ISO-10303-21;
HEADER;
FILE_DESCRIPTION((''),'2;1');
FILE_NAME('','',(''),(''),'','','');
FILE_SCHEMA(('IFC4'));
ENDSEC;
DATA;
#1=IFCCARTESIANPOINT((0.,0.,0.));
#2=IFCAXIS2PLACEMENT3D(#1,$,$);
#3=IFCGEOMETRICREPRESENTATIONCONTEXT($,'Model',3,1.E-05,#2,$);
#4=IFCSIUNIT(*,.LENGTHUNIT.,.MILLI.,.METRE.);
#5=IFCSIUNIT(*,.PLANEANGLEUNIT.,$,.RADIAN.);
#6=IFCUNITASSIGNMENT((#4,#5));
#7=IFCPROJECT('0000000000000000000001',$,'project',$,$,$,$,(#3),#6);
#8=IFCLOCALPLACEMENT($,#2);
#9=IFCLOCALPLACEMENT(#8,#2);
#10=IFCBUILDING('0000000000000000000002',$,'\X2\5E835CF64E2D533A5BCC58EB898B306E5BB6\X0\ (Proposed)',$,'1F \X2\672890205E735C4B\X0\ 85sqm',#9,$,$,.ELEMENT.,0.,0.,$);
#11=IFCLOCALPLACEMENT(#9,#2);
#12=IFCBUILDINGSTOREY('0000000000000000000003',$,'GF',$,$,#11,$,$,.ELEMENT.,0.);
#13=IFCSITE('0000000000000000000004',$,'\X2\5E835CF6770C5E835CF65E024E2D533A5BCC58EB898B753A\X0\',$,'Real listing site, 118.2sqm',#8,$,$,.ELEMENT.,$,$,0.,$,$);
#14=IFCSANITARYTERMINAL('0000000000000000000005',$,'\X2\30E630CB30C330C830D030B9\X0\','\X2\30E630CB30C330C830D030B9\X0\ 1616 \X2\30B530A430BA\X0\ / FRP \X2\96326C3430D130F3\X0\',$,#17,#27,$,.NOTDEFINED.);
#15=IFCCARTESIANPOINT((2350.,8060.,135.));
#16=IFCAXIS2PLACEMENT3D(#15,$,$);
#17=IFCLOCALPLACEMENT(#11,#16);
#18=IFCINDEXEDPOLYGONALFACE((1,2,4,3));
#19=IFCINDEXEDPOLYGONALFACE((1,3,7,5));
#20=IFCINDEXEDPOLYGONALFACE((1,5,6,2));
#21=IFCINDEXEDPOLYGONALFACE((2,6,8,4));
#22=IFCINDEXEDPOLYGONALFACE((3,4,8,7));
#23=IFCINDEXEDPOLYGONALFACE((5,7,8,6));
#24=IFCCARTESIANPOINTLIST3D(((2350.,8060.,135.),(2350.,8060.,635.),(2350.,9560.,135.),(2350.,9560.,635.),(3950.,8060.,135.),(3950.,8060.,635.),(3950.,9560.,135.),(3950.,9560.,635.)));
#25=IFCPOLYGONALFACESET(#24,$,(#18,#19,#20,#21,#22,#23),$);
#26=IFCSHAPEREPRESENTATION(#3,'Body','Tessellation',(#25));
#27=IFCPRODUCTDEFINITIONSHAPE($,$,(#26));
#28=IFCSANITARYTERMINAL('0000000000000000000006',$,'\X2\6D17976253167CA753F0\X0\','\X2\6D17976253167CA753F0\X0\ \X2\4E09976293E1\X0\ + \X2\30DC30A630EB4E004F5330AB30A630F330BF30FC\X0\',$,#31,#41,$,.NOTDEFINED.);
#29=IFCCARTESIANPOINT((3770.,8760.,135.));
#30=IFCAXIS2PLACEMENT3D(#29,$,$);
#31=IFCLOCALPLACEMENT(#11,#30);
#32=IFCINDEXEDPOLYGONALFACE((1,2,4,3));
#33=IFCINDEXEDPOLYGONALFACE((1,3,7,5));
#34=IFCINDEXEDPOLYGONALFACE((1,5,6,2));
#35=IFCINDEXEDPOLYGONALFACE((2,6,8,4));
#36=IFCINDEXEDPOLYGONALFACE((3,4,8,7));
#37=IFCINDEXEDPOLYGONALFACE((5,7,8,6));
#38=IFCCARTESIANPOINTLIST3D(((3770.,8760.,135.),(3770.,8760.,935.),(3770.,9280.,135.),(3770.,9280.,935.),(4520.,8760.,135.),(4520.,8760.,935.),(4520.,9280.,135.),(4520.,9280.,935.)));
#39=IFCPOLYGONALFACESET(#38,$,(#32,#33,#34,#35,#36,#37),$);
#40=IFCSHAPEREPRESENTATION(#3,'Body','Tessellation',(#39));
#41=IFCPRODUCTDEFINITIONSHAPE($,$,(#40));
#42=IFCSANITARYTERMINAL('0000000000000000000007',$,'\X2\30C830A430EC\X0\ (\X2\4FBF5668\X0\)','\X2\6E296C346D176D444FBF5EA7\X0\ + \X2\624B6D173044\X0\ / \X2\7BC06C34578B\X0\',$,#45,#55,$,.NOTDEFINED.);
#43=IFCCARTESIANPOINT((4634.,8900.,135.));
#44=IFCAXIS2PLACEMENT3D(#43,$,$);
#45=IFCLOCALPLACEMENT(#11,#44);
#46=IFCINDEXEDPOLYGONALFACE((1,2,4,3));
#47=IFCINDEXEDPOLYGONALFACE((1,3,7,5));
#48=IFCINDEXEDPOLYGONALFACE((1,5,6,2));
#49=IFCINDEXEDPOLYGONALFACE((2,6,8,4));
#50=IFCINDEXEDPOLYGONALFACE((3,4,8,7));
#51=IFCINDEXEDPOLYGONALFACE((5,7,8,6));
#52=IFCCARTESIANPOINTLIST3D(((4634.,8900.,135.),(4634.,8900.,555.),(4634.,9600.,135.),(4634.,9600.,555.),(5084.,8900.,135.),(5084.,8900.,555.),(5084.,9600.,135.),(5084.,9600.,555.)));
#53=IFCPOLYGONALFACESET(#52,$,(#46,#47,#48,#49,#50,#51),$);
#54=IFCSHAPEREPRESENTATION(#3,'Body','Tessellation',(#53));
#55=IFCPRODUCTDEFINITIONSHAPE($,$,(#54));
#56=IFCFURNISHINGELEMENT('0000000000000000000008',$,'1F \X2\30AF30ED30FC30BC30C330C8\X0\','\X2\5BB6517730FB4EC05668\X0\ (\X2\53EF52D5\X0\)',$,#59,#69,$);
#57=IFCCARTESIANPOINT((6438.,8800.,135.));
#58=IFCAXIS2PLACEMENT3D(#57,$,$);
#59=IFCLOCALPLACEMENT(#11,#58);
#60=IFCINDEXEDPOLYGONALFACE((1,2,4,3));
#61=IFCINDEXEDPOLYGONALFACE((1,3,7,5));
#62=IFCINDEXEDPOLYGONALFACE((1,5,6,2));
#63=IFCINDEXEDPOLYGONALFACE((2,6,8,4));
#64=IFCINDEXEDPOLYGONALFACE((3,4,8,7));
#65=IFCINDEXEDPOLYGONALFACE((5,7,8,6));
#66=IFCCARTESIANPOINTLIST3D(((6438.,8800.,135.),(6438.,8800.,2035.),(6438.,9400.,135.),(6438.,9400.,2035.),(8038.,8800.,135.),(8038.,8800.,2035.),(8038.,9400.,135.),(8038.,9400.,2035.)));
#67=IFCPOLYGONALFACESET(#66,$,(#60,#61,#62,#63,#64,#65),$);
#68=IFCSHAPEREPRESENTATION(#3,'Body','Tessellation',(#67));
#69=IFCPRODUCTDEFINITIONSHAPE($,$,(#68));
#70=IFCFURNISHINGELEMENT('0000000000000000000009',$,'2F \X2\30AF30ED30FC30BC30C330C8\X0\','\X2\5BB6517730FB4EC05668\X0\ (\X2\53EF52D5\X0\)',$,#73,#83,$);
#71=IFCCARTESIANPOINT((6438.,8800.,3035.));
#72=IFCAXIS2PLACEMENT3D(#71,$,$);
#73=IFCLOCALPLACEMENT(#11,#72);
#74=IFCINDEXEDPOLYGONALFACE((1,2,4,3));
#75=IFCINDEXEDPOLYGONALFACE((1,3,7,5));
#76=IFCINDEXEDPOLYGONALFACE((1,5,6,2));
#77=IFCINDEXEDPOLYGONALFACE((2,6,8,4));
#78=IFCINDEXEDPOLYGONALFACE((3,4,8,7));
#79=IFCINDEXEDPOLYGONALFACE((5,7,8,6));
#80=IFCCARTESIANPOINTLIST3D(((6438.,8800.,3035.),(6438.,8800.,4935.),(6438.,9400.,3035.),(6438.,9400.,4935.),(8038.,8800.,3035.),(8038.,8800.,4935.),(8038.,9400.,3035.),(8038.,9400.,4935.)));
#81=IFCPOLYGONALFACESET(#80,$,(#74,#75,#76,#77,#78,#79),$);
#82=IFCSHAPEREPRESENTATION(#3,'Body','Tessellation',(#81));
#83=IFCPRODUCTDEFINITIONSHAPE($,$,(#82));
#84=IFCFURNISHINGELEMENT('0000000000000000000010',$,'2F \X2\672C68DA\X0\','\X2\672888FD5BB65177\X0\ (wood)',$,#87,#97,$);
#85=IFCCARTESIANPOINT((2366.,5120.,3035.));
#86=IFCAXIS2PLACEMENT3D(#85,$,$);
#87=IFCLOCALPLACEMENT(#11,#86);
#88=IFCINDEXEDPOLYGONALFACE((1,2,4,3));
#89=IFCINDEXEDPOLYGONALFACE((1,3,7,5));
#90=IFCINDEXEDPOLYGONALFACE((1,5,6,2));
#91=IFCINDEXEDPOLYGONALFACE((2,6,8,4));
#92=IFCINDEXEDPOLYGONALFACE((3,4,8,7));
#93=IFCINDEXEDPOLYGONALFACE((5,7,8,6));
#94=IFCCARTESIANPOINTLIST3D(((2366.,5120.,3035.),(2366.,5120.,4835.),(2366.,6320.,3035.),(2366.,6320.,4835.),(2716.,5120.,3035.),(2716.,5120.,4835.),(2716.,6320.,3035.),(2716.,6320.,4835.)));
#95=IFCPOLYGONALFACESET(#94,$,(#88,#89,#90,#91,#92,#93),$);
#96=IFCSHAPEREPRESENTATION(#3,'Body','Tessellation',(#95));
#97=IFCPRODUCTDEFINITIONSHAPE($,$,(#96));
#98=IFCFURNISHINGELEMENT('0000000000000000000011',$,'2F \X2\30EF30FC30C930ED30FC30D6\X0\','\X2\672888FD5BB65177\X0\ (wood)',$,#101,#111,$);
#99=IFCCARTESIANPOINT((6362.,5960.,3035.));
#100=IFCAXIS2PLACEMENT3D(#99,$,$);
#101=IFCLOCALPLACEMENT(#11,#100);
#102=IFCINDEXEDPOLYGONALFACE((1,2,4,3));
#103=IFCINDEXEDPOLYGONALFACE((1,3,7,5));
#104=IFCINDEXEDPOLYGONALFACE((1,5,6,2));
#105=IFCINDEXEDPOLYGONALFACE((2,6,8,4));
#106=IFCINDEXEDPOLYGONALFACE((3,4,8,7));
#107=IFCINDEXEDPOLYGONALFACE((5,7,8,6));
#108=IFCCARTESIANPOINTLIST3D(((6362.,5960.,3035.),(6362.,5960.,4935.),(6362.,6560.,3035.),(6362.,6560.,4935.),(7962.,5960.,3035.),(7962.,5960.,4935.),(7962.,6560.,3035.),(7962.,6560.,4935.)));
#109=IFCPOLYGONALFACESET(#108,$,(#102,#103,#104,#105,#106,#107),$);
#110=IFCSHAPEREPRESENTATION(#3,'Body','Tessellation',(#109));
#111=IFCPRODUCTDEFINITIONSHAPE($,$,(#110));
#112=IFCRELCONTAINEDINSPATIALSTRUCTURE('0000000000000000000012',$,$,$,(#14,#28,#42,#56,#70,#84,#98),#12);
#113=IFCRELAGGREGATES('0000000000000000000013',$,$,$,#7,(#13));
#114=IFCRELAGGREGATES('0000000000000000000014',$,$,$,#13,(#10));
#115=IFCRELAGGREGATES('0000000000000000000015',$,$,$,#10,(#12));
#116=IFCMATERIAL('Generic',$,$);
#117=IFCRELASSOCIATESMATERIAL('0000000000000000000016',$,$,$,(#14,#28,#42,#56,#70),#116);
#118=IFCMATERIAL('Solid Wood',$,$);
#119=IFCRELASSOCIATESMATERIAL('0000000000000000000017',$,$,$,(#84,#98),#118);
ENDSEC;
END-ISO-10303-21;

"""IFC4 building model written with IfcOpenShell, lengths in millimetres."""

from ifc_helpers import new_model, si_unit, frame, frame_2d, origin, place, context, project, spatial, rectangle, extrude, material, element, save


model = new_model("IFC4")

# Units and contexts
model_context = context("Model", 3, precision=1e-05, world=origin())
ifc_project = project(units=[si_unit("LENGTHUNIT", "METRE", prefix="MILLI"), si_unit("PLANEANGLEUNIT", "RADIAN")], contexts=[model_context])

# Site, building, storey
site_placement = place(None, origin())
site = spatial("IfcSite", under=ifc_project, at=site_placement, Name="広島県広島市中区富士見町", ObjectType="Real listing site, 118.2sqm", CompositionType="ELEMENT", RefElevation=0.0)
building_placement = place(site_placement, origin())
building = spatial("IfcBuilding", under=site, at=building_placement, Name="広島中区富士見の家 (Proposed)", ObjectType="1F 木造平屋 85sqm", CompositionType="ELEMENT", ElevationOfRefHeight=0.0, ElevationOfTerrain=0.0)
storey_placement = place(building_placement, origin())
storey = spatial("IfcBuildingStorey", under=building, at=storey_placement, Name="GF", CompositionType="ELEMENT", Elevation=0.0)

# Shared definitions
ifc_material_1 = material(Name="Solid Wood")

# Shared definitions
ifc_material_2 = material(Name="Generic")

# Sanitary terminals
sanitary_terminal_1_placement = place(storey_placement, frame((2350.0, 8060.0, 135.0)))
element("IfcSanitaryTerminal", 1, at=sanitary_terminal_1_placement, inside=storey, material=ifc_material_2, Name="ユニットバス", Description="ユニットバス 1616 サイズ / FRP 防水パン", PredefinedType="NOTDEFINED", context=model_context, shape_type="SweptSolid", body=[
    extrude(rectangle(XDim=1600.0, YDim=1500.0, at=frame_2d((800.0, 750.0))), frame((2350.0, 8060.0, 135.0)), (0.0, 0.0, 1.0), 500.0),
])
sanitary_terminal_2_placement = place(storey_placement, frame((3770.0, 8760.0, 135.0)))
element("IfcSanitaryTerminal", 2, at=sanitary_terminal_2_placement, inside=storey, material=ifc_material_2, Name="洗面化粧台", Description="洗面化粧台 三面鏡 + ボウル一体カウンター", PredefinedType="NOTDEFINED", context=model_context, shape_type="SweptSolid", body=[
    extrude(rectangle(XDim=750.0, YDim=520.0, at=frame_2d((375.0, 260.0))), frame((3770.0, 8760.0, 135.0)), (0.0, 0.0, 1.0), 800.0),
])
sanitary_terminal_3_placement = place(storey_placement, frame((4634.0, 8900.0, 135.0)))
element("IfcSanitaryTerminal", 3, at=sanitary_terminal_3_placement, inside=storey, material=ifc_material_2, Name="トイレ (便器)", Description="温水洗浄便座 + 手洗い / 節水型", PredefinedType="NOTDEFINED", context=model_context, shape_type="SweptSolid", body=[
    extrude(rectangle(XDim=450.0, YDim=700.0, at=frame_2d((225.0, 350.0))), frame((4634.0, 8900.0, 135.0)), (0.0, 0.0, 1.0), 420.0),
])

# Furnishing elements
furnishing_1_placement = place(storey_placement, frame((6438.0, 8800.0, 135.0)))
element("IfcFurnishingElement", 4, at=furnishing_1_placement, inside=storey, material=ifc_material_2, Name="1F クローゼット", Description="家具・什器 (可動)", context=model_context, shape_type="SweptSolid", body=[
    extrude(rectangle(XDim=1600.0, YDim=600.0, at=frame_2d((800.0, 300.0))), frame((6438.0, 8800.0, 135.0)), (0.0, 0.0, 1.0), 1900.0),
])
furnishing_2_placement = place(storey_placement, frame((6438.0, 8800.0, 3035.0)))
element("IfcFurnishingElement", 5, at=furnishing_2_placement, inside=storey, material=ifc_material_2, Name="2F クローゼット", Description="家具・什器 (可動)", context=model_context, shape_type="SweptSolid", body=[
    extrude(rectangle(XDim=1600.0, YDim=600.0, at=frame_2d((800.0, 300.0))), frame((6438.0, 8800.0, 3035.0)), (0.0, 0.0, 1.0), 1900.0),
])
furnishing_3_placement = place(storey_placement, frame((2366.0, 5120.0, 3035.0)))
element("IfcFurnishingElement", 6, at=furnishing_3_placement, inside=storey, material=ifc_material_1, Name="2F 本棚", Description="木製家具 (wood)", context=model_context, shape_type="SweptSolid", body=[
    extrude(rectangle(XDim=350.0, YDim=1200.0, at=frame_2d((175.0, 600.0))), frame((2366.0, 5120.0, 3035.0)), (0.0, 0.0, 1.0), 1800.0),
])
furnishing_4_placement = place(storey_placement, frame((6362.0, 5960.0, 3035.0)))
element("IfcFurnishingElement", 7, at=furnishing_4_placement, inside=storey, material=ifc_material_1, Name="2F ワードローブ", Description="木製家具 (wood)", context=model_context, shape_type="SweptSolid", body=[
    extrude(rectangle(XDim=1600.0, YDim=600.0, at=frame_2d((800.0, 300.0))), frame((6362.0, 5960.0, 3035.0)), (0.0, 0.0, 1.0), 1900.0),
])

save(model, "model.ifc")
